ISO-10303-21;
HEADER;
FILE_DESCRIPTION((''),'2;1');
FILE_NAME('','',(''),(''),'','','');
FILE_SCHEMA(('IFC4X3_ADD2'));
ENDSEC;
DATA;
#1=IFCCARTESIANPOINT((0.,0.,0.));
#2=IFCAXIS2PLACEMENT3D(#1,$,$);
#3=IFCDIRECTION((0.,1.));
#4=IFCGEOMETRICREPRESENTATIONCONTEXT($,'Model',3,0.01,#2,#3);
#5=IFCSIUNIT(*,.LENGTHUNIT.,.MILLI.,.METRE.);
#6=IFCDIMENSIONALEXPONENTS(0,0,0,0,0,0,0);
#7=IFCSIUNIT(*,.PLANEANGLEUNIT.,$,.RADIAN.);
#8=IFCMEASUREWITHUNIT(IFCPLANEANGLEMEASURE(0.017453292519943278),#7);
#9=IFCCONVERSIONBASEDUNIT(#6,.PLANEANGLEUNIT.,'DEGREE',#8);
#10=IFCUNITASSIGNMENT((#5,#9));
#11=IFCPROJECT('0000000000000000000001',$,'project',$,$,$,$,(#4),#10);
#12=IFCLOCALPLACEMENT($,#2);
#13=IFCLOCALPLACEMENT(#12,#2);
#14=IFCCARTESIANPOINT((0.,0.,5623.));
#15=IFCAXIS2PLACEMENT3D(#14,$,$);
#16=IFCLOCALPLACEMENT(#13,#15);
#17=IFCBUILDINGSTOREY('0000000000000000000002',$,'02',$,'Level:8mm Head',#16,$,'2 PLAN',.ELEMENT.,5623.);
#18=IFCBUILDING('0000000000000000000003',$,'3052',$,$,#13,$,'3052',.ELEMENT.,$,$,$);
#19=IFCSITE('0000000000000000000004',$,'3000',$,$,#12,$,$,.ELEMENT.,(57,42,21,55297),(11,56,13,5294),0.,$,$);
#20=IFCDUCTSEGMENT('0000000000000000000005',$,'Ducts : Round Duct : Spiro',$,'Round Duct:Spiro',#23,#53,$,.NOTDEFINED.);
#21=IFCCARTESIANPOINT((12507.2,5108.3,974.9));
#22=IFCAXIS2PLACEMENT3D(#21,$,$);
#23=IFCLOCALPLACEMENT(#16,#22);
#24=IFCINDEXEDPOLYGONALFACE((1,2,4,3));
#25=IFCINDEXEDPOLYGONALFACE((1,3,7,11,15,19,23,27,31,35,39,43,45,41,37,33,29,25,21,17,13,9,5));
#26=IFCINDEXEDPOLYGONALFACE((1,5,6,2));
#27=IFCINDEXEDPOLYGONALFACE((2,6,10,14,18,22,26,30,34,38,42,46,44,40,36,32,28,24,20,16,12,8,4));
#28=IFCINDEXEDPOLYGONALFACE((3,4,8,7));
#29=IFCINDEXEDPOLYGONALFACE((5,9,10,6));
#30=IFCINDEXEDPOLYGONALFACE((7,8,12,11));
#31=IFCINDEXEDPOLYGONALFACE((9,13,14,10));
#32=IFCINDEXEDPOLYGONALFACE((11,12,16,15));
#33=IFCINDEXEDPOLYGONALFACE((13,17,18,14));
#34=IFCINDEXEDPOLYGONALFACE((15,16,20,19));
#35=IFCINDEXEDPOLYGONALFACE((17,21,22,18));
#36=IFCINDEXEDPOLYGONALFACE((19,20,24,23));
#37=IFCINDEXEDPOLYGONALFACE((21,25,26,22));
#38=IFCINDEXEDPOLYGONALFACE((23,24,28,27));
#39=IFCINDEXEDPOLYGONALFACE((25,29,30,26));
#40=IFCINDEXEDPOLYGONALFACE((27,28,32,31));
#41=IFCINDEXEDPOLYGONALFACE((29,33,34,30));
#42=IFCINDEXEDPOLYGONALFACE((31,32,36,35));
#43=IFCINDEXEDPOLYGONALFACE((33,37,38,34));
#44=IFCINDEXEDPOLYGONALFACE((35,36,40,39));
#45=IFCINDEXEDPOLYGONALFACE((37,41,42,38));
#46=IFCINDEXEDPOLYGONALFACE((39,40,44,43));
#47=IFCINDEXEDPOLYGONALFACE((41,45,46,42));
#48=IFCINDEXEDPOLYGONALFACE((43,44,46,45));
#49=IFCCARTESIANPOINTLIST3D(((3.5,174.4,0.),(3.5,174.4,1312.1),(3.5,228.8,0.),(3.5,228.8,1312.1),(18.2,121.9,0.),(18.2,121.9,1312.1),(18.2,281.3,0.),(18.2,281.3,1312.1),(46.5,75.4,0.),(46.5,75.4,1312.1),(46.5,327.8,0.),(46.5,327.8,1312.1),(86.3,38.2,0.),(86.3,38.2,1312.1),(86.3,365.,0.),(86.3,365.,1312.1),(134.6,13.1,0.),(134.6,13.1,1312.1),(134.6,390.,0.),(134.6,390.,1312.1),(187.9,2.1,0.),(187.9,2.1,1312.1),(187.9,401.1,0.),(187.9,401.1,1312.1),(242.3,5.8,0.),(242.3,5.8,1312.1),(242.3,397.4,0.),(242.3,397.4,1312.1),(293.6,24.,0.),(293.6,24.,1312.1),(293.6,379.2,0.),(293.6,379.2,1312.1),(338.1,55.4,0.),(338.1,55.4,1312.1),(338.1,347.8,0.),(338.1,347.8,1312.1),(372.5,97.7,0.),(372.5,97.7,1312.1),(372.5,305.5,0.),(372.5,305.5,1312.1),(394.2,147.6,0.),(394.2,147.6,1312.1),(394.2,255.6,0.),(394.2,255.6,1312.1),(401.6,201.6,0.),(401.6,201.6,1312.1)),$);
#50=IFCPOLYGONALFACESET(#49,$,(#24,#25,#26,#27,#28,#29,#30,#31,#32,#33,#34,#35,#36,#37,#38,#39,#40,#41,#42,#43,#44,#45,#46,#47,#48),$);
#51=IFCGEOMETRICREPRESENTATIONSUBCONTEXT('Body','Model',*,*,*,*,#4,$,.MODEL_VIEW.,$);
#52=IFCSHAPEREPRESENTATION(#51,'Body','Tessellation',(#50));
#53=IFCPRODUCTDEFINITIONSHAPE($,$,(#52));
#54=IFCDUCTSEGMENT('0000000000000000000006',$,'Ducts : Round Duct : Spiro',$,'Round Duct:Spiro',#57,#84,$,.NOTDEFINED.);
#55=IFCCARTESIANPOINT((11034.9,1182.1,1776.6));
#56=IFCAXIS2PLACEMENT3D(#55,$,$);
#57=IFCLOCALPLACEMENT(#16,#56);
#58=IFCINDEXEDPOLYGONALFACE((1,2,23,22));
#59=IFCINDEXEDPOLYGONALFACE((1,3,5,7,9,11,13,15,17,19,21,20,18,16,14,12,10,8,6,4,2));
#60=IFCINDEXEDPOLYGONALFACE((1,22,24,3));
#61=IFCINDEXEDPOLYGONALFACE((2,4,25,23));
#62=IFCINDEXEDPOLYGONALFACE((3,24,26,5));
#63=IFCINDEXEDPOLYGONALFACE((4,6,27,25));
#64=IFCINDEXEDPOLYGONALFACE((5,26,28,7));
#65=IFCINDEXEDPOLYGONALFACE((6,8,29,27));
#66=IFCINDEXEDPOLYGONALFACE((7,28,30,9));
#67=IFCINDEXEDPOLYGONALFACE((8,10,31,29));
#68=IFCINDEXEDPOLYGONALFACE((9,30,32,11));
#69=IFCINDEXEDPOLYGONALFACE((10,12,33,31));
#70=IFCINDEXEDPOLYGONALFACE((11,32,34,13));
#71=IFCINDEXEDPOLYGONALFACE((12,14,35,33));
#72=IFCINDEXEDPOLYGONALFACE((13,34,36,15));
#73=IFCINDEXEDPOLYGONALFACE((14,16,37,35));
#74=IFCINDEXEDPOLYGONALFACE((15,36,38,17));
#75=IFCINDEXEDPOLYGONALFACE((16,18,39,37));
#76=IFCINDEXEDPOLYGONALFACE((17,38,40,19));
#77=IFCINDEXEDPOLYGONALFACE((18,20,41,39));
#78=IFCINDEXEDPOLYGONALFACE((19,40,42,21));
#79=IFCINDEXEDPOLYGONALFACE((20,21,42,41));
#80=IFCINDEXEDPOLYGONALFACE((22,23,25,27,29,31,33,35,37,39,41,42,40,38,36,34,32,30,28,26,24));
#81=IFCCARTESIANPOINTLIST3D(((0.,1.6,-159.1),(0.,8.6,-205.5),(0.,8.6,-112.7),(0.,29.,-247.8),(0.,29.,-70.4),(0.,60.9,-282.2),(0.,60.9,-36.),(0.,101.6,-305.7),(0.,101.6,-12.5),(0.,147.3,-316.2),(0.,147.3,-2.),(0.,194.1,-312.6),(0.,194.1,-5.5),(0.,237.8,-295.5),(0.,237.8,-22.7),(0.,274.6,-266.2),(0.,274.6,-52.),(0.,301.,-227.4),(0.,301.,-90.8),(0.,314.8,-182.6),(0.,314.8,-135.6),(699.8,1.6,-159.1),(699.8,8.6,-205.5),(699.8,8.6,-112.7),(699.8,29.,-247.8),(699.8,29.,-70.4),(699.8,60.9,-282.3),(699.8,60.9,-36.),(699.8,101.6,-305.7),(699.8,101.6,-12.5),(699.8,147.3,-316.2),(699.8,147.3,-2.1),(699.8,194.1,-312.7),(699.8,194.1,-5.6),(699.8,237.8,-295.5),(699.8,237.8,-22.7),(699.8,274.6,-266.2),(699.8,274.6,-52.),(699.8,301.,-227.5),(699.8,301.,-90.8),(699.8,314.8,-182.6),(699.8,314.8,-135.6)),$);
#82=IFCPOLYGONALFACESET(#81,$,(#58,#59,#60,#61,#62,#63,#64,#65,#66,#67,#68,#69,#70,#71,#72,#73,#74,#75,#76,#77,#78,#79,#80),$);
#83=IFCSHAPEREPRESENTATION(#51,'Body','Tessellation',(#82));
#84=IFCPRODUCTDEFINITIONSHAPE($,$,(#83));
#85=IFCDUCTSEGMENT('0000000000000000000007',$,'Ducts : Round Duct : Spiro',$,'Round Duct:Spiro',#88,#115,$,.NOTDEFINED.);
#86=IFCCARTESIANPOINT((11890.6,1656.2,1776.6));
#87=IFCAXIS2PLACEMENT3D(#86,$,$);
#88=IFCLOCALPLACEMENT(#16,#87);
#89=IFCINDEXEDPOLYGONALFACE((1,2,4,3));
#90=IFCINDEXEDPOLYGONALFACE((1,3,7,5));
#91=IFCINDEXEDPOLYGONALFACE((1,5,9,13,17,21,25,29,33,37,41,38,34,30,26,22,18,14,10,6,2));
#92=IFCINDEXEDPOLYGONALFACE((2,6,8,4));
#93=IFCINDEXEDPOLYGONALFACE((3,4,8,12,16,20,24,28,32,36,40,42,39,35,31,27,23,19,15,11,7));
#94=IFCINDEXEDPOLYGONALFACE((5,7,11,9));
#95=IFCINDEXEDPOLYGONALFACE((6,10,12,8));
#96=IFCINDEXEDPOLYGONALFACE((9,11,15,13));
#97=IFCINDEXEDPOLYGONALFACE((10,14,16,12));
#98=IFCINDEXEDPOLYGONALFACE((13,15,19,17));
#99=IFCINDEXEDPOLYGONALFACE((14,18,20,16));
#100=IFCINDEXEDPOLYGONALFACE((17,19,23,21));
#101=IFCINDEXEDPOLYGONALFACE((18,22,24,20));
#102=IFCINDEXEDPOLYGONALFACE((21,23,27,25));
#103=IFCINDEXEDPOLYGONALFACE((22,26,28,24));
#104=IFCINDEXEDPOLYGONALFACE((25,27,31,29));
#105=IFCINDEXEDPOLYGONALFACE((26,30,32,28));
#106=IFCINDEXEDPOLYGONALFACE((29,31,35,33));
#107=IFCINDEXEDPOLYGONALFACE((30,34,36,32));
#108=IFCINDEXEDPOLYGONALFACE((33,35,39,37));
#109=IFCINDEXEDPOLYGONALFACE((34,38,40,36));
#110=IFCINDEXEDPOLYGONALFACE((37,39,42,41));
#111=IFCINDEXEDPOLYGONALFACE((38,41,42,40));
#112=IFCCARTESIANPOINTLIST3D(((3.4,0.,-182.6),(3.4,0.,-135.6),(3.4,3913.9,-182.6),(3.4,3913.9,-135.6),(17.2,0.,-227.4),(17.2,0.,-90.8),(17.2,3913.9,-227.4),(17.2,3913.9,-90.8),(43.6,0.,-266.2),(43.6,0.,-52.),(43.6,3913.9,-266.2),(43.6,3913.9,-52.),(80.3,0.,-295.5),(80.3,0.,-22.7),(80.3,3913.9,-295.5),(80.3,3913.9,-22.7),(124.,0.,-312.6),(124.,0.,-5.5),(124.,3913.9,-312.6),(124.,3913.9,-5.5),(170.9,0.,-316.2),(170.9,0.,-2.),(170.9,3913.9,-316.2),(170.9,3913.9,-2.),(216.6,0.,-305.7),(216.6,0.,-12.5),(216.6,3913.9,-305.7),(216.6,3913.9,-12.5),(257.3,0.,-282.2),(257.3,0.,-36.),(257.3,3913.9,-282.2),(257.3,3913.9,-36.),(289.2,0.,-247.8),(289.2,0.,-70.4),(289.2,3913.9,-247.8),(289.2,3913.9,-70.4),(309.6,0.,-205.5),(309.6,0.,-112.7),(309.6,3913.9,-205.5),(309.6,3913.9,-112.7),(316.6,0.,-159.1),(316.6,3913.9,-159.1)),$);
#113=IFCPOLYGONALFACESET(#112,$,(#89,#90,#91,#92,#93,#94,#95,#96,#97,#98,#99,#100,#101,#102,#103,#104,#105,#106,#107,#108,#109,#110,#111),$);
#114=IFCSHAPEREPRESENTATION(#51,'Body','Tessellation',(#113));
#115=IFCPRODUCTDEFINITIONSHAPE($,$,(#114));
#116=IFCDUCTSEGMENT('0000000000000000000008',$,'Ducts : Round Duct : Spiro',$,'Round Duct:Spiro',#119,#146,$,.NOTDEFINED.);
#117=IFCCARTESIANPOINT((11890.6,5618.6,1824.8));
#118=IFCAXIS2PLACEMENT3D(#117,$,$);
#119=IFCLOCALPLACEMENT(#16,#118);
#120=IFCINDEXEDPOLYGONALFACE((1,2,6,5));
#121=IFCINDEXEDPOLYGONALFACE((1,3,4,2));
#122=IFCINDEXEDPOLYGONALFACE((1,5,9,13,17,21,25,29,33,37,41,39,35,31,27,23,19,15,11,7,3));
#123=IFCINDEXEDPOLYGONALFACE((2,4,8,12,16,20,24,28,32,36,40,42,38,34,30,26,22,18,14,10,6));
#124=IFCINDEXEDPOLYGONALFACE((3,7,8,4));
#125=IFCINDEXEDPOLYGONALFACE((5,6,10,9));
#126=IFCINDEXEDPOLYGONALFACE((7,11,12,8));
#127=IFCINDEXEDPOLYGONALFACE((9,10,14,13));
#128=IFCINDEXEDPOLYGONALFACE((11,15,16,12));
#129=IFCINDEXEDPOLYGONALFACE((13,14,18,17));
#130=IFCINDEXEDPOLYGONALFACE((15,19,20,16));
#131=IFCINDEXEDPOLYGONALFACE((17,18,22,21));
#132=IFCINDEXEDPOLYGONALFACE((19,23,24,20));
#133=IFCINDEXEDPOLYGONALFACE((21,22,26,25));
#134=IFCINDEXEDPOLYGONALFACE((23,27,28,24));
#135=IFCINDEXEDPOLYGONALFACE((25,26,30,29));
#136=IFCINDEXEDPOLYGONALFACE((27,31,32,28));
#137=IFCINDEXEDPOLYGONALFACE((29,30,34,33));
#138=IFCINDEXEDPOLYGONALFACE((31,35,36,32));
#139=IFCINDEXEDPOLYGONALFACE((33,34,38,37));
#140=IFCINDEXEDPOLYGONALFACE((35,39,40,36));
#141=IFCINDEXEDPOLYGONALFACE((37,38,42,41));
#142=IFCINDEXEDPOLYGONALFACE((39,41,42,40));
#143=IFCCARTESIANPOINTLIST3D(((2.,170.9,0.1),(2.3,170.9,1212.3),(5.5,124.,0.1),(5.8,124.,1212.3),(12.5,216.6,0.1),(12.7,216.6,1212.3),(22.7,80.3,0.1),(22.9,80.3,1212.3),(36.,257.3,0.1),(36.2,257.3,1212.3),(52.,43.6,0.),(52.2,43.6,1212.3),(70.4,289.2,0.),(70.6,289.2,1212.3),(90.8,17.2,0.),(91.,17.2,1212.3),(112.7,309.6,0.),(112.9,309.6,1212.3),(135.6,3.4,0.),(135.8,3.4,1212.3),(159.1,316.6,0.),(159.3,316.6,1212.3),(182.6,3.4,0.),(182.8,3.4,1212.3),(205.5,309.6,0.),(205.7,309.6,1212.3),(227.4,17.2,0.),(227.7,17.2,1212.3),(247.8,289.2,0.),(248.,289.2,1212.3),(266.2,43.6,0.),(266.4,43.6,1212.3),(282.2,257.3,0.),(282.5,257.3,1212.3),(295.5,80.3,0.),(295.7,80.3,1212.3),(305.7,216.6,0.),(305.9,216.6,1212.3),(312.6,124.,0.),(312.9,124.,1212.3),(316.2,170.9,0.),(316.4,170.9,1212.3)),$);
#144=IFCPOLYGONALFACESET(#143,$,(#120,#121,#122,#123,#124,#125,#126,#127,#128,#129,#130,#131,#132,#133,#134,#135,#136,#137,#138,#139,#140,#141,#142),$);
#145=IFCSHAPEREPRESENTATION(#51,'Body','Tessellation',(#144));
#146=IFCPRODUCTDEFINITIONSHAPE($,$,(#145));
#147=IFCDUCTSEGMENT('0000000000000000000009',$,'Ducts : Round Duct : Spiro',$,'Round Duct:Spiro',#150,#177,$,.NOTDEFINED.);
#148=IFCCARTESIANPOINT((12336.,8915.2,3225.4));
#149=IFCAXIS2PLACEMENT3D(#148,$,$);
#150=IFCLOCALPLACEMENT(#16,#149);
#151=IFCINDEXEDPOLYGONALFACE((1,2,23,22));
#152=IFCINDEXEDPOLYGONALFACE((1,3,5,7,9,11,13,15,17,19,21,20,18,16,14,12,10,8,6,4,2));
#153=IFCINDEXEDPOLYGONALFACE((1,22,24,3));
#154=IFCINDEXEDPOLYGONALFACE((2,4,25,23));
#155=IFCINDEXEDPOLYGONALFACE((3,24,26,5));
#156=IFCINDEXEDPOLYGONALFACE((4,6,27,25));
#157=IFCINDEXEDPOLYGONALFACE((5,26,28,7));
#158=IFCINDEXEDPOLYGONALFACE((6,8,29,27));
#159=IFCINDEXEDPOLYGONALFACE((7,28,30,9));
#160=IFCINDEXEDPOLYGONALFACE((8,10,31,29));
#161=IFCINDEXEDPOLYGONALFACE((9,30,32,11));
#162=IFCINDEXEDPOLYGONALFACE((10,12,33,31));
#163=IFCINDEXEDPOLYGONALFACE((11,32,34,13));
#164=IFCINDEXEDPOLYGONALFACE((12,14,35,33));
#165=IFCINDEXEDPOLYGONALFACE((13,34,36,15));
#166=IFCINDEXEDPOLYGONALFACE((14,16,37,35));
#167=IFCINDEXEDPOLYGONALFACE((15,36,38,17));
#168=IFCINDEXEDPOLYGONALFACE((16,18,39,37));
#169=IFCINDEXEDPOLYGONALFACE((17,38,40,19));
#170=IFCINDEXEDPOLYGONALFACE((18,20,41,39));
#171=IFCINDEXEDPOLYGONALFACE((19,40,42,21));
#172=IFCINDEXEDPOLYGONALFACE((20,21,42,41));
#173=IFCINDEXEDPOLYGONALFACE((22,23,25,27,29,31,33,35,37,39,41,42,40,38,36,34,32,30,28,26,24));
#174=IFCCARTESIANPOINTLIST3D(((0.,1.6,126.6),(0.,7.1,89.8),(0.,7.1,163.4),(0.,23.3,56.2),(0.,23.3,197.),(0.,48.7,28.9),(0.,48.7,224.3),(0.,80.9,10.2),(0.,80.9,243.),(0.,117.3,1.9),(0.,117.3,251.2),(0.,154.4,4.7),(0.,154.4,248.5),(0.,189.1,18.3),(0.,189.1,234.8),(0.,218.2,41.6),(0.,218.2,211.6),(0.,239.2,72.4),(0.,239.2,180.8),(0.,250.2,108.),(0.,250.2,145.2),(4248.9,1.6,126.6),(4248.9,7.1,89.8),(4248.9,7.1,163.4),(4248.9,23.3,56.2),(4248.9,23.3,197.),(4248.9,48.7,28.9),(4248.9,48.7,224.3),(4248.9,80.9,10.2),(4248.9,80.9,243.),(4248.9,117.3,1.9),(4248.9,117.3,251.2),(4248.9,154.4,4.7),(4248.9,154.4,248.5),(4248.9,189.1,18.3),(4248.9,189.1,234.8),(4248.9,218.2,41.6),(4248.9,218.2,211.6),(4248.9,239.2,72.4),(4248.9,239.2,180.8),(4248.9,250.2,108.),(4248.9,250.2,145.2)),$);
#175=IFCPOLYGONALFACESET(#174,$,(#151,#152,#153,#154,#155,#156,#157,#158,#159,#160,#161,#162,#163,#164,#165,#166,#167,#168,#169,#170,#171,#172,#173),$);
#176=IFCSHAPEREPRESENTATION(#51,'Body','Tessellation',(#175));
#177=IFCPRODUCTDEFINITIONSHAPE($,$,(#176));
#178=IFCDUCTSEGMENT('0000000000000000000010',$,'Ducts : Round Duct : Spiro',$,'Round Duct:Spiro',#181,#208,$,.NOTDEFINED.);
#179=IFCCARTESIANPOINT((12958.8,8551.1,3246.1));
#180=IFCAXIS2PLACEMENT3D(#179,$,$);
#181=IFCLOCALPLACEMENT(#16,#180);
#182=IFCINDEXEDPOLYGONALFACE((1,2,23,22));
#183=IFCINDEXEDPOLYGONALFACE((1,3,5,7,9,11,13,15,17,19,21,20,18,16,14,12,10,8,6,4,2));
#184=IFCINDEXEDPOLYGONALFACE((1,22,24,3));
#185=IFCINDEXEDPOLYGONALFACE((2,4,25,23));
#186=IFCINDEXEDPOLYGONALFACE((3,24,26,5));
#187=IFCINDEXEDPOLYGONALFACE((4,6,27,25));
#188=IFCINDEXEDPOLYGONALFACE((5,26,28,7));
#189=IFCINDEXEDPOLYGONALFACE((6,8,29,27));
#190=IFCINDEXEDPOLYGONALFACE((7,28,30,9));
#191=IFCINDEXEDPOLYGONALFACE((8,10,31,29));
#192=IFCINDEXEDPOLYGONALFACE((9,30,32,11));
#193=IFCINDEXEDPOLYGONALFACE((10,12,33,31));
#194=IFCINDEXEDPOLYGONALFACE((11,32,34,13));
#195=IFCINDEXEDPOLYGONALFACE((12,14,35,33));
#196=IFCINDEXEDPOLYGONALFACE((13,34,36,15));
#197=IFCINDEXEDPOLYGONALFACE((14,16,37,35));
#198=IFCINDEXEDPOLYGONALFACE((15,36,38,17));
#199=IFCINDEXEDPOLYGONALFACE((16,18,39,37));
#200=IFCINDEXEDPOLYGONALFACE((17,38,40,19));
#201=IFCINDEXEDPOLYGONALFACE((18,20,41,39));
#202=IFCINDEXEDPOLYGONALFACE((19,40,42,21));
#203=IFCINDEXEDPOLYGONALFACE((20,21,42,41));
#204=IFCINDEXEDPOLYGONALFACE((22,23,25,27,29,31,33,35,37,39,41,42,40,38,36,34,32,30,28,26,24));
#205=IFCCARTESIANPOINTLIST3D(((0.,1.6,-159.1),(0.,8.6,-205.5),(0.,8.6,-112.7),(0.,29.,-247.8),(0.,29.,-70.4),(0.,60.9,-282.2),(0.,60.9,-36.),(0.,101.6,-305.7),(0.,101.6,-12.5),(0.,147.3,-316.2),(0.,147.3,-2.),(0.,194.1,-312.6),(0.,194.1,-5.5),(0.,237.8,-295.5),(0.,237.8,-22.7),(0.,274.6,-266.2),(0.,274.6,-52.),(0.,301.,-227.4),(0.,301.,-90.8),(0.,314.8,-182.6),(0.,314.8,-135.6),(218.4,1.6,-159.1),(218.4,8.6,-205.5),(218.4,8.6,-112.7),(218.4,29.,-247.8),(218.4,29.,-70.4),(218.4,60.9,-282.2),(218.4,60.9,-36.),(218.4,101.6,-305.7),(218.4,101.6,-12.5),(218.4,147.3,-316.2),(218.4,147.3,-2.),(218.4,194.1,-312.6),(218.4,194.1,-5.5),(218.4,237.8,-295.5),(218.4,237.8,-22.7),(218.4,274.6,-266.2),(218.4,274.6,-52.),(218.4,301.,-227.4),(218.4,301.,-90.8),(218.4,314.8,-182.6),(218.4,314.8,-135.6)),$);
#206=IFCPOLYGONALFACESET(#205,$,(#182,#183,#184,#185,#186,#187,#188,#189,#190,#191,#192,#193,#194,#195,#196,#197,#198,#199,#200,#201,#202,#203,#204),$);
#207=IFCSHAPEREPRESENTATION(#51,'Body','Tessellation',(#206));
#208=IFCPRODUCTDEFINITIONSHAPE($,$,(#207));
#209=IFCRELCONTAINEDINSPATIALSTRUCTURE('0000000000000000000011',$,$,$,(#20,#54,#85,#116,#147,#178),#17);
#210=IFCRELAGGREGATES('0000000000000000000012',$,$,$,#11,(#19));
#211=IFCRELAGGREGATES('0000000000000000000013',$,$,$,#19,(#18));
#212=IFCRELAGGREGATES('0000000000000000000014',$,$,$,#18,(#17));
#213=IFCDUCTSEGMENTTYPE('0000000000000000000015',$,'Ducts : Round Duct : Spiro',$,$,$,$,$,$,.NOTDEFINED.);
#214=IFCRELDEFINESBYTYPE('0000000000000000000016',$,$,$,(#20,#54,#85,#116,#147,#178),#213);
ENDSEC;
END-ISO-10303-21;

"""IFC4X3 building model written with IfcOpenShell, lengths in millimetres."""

from ifc_helpers import new_model, entity, si_unit, converted_unit, direction, frame, frame_2d, origin, place, context, subcontext, project, spatial, circle, extrude, type_object, element, save


model = new_model("IFC4X3")

# Units and contexts
model_context = context("Model", 3, precision=0.01, world=origin(), true_north=direction((0.0, 1.0)))
body_context = subcontext(model_context, "Body", "Model", "MODEL_VIEW")
ifc_project = project(units=[si_unit("LENGTHUNIT", "METRE", prefix="MILLI"), converted_unit("PLANEANGLEUNIT", "DEGREE", entity("IfcPlaneAngleMeasure", 0.017453292519943278), si_unit("PLANEANGLEUNIT", "RADIAN"), dimensions=[0, 0, 0, 0, 0, 0, 0])], contexts=[model_context])

# Site, building, storey
site_placement = place(None, origin())
site = spatial("IfcSite", under=ifc_project, at=site_placement, Name="3000", CompositionType="ELEMENT", RefLatitude=(57, 42, 21, 55297), RefLongitude=(11, 56, 13, 5294), RefElevation=0.0)
building_placement = place(site_placement, origin())
building = spatial("IfcBuilding", under=site, at=building_placement, Name="3052", LongName="3052", CompositionType="ELEMENT")
storey_placement = place(building_placement, frame((0.0, 0.0, 5623.0)))
storey = spatial("IfcBuildingStorey", under=building, at=storey_placement, Name="02", ObjectType="Level:8mm Head", LongName="2 PLAN", CompositionType="ELEMENT", Elevation=5623.0)

# Duct segments
duct_segment_type = type_object("IfcDuctSegmentType", Name="Ducts : Round Duct : Spiro", PredefinedType="NOTDEFINED")
duct_segment_1_placement = place(storey_placement, frame((12507.2, 5108.3, 974.9)))
element("IfcDuctSegment", 1, at=duct_segment_1_placement, inside=storey, type_object=duct_segment_type, Name="Ducts : Round Duct : Spiro", ObjectType="Round Duct:Spiro", PredefinedType="NOTDEFINED", context=body_context, shape_type="SweptSolid", body=[
    extrude(circle(Radius=200.0, at=frame_2d((0.0, 0.0), x_axis=(1.0, 0.0))), frame((201.6, 201.6, 0.0)), (0.0, 0.0, 1.0), 1312.1),
])
duct_segment_2_placement = place(storey_placement, frame((11034.9, 1182.1, 1776.6)))
element("IfcDuctSegment", 2, at=duct_segment_2_placement, inside=storey, type_object=duct_segment_type, Name="Ducts : Round Duct : Spiro", ObjectType="Round Duct:Spiro", PredefinedType="NOTDEFINED", context=body_context, shape_type="SweptSolid", body=[
    extrude(circle(Radius=157.5, at=frame_2d((0.0, 0.0), x_axis=(1.0, 0.0))), frame((699.8, 159.1, -159.1), z_axis=(-1.0, 0.0, 0.000037), x_axis=(0.0, -1.0, 0.0)), (0.0, 0.0, 1.0), 699.8),
])
duct_segment_3_placement = place(storey_placement, frame((11890.6, 1656.2, 1776.6)))
element("IfcDuctSegment", 3, at=duct_segment_3_placement, inside=storey, type_object=duct_segment_type, Name="Ducts : Round Duct : Spiro", ObjectType="Round Duct:Spiro", PredefinedType="NOTDEFINED", context=body_context, shape_type="SweptSolid", body=[
    extrude(circle(Radius=157.5, at=frame_2d((0.0, 0.0), x_axis=(1.0, 0.0))), frame((159.1, 0.0, -159.1), z_axis=(0.0, 1.0, 0.0), x_axis=(1.0, 0.0, 0.0)), (0.0, 0.0, 1.0), 3913.9),
])
duct_segment_4_placement = place(storey_placement, frame((11890.6, 5618.6, 1824.8)))
element("IfcDuctSegment", 4, at=duct_segment_4_placement, inside=storey, type_object=duct_segment_type, Name="Ducts : Round Duct : Spiro", ObjectType="Round Duct:Spiro", PredefinedType="NOTDEFINED", context=body_context, shape_type="SweptSolid", body=[
    extrude(circle(Radius=157.5, at=frame_2d((0.0, 0.0), x_axis=(1.0, 0.0))), frame((159.1, 159.1, 0.0), z_axis=(0.000181, 0.0, 1.0), x_axis=(0.0, 1.0, 0.0)), (0.0, 0.0, 1.0), 1212.3),
])
duct_segment_5_placement = place(storey_placement, frame((12336.0, 8915.2, 3225.4)))
element("IfcDuctSegment", 5, at=duct_segment_5_placement, inside=storey, type_object=duct_segment_type, Name="Ducts : Round Duct : Spiro", ObjectType="Round Duct:Spiro", PredefinedType="NOTDEFINED", context=body_context, shape_type="SweptSolid", body=[
    extrude(circle(Radius=125.0, at=frame_2d((0.0, 0.0), x_axis=(1.0, 0.0))), frame((0.0, 126.6, 126.6), z_axis=(1.0, 0.0, 0.0), x_axis=(0.0, -1.0, 0.0)), (0.0, 0.0, 1.0), 4248.9),
])
duct_segment_6_placement = place(storey_placement, frame((12958.8, 8551.1, 3246.1)))
element("IfcDuctSegment", 6, at=duct_segment_6_placement, inside=storey, type_object=duct_segment_type, Name="Ducts : Round Duct : Spiro", ObjectType="Round Duct:Spiro", PredefinedType="NOTDEFINED", context=body_context, shape_type="SweptSolid", body=[
    extrude(circle(Radius=157.5, at=frame_2d((0.0, 0.0), x_axis=(1.0, 0.0))), frame((0.0, 159.1, -159.1), z_axis=(1.0, 0.0, 0.0), x_axis=(0.0, -1.0, 0.0)), (0.0, 0.0, 1.0), 218.4),
])

save(model, "model.ifc")
